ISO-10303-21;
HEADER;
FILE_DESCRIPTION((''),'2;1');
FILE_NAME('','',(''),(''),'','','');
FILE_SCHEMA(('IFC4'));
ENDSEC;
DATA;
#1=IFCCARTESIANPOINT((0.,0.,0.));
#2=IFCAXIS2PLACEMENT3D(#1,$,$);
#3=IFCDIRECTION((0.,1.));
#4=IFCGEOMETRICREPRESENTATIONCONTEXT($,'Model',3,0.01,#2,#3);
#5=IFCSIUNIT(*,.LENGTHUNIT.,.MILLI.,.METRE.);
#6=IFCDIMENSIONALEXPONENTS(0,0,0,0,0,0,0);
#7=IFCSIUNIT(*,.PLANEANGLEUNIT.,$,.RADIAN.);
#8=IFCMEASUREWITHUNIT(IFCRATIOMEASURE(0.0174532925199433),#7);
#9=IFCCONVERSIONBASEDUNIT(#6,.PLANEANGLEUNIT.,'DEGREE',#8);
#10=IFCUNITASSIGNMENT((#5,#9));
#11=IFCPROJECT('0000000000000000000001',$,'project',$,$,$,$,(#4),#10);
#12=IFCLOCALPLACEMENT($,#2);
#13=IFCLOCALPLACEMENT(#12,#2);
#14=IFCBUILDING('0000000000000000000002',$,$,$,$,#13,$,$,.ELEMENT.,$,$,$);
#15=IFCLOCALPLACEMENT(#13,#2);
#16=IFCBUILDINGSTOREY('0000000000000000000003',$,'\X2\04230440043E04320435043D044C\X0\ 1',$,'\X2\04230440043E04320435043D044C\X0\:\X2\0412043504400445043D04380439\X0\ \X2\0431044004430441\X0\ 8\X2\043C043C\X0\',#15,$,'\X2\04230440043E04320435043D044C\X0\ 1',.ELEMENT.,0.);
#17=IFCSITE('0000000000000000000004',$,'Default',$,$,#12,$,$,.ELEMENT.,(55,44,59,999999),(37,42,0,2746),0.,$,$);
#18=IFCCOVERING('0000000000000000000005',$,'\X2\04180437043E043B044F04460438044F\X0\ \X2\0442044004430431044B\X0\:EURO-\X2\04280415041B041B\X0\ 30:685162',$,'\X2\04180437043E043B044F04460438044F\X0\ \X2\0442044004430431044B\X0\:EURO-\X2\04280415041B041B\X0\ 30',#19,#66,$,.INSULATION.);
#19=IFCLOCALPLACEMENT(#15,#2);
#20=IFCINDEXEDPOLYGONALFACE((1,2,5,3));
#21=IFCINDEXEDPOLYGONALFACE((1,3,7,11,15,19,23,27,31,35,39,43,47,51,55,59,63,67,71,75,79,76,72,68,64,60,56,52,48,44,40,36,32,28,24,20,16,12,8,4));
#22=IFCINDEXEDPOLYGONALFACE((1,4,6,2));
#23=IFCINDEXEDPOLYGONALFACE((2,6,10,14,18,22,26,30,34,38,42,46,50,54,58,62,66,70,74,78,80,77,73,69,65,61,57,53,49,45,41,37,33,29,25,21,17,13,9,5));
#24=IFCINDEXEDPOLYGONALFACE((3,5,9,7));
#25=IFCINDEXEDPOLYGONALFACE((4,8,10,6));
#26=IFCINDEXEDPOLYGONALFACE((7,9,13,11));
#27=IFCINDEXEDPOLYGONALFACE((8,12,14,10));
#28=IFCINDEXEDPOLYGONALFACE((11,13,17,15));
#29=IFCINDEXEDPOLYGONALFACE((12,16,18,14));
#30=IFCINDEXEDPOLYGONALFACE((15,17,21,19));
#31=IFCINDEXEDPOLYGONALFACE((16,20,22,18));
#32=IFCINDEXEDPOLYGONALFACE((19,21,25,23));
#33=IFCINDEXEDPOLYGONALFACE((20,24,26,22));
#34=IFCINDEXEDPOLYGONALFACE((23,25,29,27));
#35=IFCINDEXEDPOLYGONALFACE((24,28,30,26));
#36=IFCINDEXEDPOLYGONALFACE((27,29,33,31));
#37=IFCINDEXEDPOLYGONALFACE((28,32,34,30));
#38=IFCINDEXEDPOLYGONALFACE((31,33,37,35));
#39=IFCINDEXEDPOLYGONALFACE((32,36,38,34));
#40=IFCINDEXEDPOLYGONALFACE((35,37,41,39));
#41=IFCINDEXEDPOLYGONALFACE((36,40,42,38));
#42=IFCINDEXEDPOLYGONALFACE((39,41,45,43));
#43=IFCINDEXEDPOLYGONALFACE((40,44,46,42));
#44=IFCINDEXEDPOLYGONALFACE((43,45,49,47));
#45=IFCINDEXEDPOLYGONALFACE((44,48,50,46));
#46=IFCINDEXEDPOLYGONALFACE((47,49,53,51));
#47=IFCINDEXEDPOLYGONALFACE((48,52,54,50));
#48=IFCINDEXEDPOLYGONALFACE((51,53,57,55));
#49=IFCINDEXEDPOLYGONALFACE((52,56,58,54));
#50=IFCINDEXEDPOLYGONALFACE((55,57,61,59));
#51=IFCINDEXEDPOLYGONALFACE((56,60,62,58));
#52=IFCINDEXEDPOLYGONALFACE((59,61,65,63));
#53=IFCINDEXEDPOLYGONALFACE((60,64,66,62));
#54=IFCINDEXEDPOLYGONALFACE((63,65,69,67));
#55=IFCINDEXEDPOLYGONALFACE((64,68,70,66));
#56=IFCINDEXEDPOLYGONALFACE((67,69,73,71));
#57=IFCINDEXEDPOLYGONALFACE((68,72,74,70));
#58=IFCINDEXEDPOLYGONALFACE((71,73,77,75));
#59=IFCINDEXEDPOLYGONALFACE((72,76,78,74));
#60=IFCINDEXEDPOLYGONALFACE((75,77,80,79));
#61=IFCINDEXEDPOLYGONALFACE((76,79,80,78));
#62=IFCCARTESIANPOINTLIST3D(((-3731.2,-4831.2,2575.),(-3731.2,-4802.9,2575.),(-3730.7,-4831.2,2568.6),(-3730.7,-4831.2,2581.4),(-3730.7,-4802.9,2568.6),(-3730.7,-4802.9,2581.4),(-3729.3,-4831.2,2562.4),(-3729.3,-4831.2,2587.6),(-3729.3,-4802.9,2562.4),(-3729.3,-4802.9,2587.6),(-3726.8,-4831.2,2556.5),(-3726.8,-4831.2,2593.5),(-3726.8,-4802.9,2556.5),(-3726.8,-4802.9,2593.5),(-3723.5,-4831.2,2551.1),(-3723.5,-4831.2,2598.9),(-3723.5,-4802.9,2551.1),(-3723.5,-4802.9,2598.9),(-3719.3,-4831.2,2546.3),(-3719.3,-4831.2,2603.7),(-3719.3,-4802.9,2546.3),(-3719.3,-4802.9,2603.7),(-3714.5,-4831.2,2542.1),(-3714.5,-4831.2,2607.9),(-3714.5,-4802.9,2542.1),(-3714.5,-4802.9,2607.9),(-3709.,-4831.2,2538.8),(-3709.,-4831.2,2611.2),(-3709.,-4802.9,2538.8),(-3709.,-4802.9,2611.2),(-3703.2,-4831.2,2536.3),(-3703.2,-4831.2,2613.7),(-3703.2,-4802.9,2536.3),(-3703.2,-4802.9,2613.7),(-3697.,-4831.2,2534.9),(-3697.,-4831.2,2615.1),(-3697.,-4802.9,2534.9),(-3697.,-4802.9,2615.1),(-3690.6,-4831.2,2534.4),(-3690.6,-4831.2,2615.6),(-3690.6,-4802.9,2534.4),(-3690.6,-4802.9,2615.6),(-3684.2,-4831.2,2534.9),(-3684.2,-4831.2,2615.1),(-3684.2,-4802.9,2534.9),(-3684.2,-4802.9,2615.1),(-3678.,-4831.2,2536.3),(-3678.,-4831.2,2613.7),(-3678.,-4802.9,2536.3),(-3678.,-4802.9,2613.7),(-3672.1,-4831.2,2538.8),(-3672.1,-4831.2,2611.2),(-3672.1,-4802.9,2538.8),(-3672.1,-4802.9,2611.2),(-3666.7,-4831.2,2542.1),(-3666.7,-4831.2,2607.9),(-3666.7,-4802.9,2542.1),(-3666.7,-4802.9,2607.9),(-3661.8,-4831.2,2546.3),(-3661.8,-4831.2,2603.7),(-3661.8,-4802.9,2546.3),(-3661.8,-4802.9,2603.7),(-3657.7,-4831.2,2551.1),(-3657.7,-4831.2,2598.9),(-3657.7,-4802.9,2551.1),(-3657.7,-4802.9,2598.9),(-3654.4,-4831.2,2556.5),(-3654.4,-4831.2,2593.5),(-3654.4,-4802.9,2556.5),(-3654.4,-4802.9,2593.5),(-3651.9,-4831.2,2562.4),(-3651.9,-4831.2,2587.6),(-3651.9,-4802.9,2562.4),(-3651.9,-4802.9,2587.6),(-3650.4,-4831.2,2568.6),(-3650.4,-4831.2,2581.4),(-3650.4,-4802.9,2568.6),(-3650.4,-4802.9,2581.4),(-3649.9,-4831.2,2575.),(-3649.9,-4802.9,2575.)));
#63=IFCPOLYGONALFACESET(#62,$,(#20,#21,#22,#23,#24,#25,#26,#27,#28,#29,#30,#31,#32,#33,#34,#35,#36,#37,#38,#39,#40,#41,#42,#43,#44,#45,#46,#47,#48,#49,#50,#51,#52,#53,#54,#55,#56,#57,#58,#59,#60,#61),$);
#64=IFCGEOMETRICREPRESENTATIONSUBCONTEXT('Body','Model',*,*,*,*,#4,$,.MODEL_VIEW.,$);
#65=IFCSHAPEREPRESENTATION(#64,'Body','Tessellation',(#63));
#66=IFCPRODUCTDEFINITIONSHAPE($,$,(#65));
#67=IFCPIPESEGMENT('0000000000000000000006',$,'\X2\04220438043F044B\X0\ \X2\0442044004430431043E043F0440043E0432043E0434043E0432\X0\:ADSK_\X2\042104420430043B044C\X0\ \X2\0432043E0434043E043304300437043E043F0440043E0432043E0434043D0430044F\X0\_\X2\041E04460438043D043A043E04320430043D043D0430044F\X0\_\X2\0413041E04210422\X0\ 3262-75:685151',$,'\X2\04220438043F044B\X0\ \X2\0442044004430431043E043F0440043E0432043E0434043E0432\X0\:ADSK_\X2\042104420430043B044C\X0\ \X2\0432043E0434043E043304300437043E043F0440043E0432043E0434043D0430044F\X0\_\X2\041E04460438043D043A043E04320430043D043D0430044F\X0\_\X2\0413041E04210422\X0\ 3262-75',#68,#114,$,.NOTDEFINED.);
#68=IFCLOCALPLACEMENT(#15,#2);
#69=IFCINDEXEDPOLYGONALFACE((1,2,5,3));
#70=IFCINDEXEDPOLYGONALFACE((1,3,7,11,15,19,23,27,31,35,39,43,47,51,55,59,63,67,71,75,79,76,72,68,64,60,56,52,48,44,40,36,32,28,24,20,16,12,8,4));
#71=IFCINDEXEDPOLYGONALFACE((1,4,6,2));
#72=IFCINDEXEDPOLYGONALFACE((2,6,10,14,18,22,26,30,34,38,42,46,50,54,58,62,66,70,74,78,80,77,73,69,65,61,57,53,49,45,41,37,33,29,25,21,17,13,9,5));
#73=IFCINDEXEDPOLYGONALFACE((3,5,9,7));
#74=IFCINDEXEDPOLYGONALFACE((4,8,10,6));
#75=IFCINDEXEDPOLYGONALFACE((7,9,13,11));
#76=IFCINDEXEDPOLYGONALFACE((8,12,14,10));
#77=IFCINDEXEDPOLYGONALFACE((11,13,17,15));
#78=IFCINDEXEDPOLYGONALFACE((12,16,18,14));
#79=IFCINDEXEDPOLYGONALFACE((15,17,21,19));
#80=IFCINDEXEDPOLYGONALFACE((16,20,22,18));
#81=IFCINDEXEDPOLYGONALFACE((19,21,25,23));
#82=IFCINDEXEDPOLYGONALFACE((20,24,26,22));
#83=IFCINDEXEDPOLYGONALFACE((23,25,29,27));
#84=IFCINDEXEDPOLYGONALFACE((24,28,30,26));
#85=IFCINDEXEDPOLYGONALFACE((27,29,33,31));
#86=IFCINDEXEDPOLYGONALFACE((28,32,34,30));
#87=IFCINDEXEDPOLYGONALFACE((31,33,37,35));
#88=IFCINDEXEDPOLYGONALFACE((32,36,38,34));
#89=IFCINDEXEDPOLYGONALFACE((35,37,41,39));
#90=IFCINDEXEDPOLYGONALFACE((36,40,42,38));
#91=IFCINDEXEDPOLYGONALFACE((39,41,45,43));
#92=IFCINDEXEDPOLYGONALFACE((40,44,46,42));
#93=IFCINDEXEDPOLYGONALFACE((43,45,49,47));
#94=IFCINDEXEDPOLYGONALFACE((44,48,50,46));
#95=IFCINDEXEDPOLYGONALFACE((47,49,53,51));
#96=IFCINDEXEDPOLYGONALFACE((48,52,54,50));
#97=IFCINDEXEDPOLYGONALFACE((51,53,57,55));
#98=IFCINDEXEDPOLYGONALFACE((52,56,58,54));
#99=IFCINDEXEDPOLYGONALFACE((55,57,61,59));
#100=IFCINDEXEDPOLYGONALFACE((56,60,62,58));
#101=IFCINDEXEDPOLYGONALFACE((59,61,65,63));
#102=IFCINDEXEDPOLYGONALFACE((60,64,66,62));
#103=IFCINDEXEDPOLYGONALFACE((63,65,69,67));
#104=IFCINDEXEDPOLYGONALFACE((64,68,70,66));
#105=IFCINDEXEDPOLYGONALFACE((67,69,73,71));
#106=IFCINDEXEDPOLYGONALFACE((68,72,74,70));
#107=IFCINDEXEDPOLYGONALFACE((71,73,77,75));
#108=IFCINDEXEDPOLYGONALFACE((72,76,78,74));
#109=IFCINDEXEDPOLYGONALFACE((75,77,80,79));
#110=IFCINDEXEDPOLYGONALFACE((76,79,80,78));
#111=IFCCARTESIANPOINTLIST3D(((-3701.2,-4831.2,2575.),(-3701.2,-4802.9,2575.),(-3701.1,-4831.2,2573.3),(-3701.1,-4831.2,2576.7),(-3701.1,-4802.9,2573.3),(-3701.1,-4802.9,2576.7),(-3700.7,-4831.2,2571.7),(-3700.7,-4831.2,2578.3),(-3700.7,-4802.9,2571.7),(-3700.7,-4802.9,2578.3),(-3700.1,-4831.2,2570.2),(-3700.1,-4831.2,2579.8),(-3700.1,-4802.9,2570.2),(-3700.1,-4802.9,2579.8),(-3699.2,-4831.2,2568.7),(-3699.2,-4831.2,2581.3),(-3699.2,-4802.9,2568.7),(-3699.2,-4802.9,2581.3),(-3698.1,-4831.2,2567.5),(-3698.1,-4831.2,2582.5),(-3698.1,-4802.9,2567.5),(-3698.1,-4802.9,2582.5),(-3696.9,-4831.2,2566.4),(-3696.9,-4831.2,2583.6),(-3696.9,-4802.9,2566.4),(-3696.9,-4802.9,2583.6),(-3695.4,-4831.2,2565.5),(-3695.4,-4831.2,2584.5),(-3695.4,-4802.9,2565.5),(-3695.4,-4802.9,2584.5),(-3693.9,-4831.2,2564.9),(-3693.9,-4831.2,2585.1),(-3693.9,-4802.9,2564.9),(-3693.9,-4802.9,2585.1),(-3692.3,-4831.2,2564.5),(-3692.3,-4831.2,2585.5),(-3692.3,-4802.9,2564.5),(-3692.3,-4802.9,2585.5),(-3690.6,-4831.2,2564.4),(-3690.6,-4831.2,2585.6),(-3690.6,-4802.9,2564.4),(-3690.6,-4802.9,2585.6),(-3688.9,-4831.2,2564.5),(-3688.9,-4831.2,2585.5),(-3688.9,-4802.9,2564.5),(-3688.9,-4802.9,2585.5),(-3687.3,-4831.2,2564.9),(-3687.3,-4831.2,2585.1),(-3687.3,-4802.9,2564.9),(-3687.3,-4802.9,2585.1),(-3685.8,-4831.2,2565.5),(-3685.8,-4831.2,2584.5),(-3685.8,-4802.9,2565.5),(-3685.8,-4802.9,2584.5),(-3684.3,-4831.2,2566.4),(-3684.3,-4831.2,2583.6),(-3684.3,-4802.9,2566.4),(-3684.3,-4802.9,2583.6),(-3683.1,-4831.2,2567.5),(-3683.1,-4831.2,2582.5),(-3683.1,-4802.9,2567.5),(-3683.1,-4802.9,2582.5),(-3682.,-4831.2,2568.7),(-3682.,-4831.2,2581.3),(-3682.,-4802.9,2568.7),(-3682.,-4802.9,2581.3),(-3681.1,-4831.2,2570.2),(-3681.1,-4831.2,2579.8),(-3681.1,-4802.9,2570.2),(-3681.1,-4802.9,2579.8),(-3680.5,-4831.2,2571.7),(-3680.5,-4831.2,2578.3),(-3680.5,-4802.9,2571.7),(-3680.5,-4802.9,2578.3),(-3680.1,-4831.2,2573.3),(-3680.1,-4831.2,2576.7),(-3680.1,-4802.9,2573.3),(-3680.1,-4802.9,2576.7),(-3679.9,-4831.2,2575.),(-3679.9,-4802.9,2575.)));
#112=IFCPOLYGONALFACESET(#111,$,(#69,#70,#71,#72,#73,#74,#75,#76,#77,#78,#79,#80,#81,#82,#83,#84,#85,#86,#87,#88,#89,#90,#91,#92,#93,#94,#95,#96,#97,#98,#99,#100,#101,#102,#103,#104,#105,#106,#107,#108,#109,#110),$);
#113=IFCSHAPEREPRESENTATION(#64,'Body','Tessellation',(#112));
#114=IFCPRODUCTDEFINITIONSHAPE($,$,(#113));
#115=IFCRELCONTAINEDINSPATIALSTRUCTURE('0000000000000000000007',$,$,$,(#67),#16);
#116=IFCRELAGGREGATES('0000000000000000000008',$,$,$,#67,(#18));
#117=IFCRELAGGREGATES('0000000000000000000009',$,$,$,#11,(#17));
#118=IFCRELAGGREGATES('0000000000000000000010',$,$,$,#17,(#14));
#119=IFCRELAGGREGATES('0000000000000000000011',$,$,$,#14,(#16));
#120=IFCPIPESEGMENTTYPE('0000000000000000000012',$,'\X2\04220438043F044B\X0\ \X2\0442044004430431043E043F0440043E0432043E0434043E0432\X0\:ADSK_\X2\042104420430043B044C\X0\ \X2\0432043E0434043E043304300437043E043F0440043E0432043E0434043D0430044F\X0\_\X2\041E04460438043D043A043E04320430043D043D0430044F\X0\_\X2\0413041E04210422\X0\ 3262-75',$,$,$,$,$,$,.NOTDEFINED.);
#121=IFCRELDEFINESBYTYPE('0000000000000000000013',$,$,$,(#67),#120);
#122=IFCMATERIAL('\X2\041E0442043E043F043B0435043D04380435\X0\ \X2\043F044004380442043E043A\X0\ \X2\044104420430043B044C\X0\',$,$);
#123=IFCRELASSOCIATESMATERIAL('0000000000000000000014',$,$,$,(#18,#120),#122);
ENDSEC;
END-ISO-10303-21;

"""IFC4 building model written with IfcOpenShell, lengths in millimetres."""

from ifc_helpers import new_model, entity, si_unit, converted_unit, direction, frame, origin, place, context, subcontext, project, spatial, indexed_curve, outline, extrude, material, type_object, element, aggregate, save


model = new_model("IFC4")

# Units and contexts
model_context = context("Model", 3, precision=0.01, world=origin(), true_north=direction((0.0, 1.0)))
body_context = subcontext(model_context, "Body", "Model", "MODEL_VIEW")
ifc_project = project(units=[si_unit("LENGTHUNIT", "METRE", prefix="MILLI"), converted_unit("PLANEANGLEUNIT", "DEGREE", entity("IfcRatioMeasure", 0.0174532925199433), si_unit("PLANEANGLEUNIT", "RADIAN"), dimensions=[0, 0, 0, 0, 0, 0, 0])], contexts=[model_context])

# Site, building, storey
site_placement = place(None, origin())
site = spatial("IfcSite", under=ifc_project, at=site_placement, Name="Default", CompositionType="ELEMENT", RefLatitude=(55, 44, 59, 999999), RefLongitude=(37, 42, 0, 2746), RefElevation=0.0)
building_placement = place(site_placement, origin())
building = spatial("IfcBuilding", under=site, at=building_placement, CompositionType="ELEMENT")
storey_placement = place(building_placement, origin())
storey = spatial("IfcBuildingStorey", under=building, at=storey_placement, Name="Уровень 1", ObjectType="Уровень:Верхний брус 8мм", LongName="Уровень 1", CompositionType="ELEMENT", Elevation=0.0)

# Covering
ifc_material_1 = material(Name="Отопление приток сталь")
covering_1_placement = place(storey_placement, origin())
covering_1 = element("IfcCovering", 1, at=covering_1_placement, material=ifc_material_1, Name="Изоляция трубы:EURO-ШЕЛЛ 30:685162", ObjectType="Изоляция трубы:EURO-ШЕЛЛ 30", PredefinedType="INSULATION", context=body_context, shape_type="SweptSolid", body=[
    extrude(outline(indexed_curve([(40.6, 0.0), (40.1, 6.4), (38.7, 12.6), (36.2, 18.5), (32.9, 23.9), (28.7, 28.7), (23.9, 32.9), (18.5, 36.2), (12.6, 38.7), (6.4, 40.1), (0.0, 40.6), (-6.4, 40.1), (-12.6, 38.7), (-18.5, 36.2), (-23.9, 32.9), (-28.7, 28.7), (-32.9, 23.9), (-36.2, 18.5), (-38.7, 12.6), (-40.1, 6.4), (-40.6, 0.0), (-40.1, -6.4), (-38.7, -12.6), (-36.2, -18.5), (-32.9, -23.9), (-28.7, -28.7), (-23.9, -32.9), (-18.5, -36.2), (-12.6, -38.7), (-6.4, -40.1), (0.0, -40.6), (6.4, -40.1), (12.6, -38.7), (18.5, -36.2), (23.9, -32.9), (28.7, -28.7), (32.9, -23.9), (36.2, -18.5), (38.7, -12.6), (40.1, -6.4), (40.6, 0.0)], self_intersect=False)), frame((-3690.6, -4831.2, 2575.0), z_axis=(0.0, 1.0, 0.0), x_axis=(-1.0, 0.0, 0.0)), (0.0, 0.0, 1.0), 28.3),
])

# Pipe segment
pipe_segment_type_1 = type_object("IfcPipeSegmentType", Name="Типы трубопроводов:ADSK_Сталь водогазопроводная_Оцинкованная_ГОСТ 3262-75", PredefinedType="NOTDEFINED", material=ifc_material_1)
pipe_segment_1_placement = place(storey_placement, origin())
pipe_segment_1 = element("IfcPipeSegment", 2, at=pipe_segment_1_placement, inside=storey, type_object=pipe_segment_type_1, Name="Типы трубопроводов:ADSK_Сталь водогазопроводная_Оцинкованная_ГОСТ 3262-75:685151", ObjectType="Типы трубопроводов:ADSK_Сталь водогазопроводная_Оцинкованная_ГОСТ 3262-75", PredefinedType="NOTDEFINED", context=body_context, shape_type="SweptSolid", body=[
    extrude(outline(indexed_curve([(10.6, 0.0), (10.5, 1.7), (10.1, 3.3), (9.5, 4.8), (8.6, 6.3), (7.5, 7.5), (6.3, 8.6), (4.8, 9.5), (3.3, 10.1), (1.7, 10.5), (0.0, 10.6), (-1.7, 10.5), (-3.3, 10.1), (-4.8, 9.5), (-6.3, 8.6), (-7.5, 7.5), (-8.6, 6.3), (-9.5, 4.8), (-10.1, 3.3), (-10.5, 1.7), (-10.6, 0.0), (-10.5, -1.7), (-10.1, -3.3), (-9.5, -4.8), (-8.6, -6.3), (-7.5, -7.5), (-6.3, -8.6), (-4.8, -9.5), (-3.3, -10.1), (-1.7, -10.5), (0.0, -10.6), (1.7, -10.5), (3.3, -10.1), (4.8, -9.5), (6.3, -8.6), (7.5, -7.5), (8.6, -6.3), (9.5, -4.8), (10.1, -3.3), (10.5, -1.7), (10.6, 0.0)], self_intersect=False)), frame((-3690.6, -4831.2, 2575.0), z_axis=(0.0, 1.0, 0.0), x_axis=(1.0, 0.0, 0.0)), (0.0, 0.0, 1.0), 28.3),
])
aggregate(pipe_segment_1, [covering_1])

save(model, "model.ifc")
